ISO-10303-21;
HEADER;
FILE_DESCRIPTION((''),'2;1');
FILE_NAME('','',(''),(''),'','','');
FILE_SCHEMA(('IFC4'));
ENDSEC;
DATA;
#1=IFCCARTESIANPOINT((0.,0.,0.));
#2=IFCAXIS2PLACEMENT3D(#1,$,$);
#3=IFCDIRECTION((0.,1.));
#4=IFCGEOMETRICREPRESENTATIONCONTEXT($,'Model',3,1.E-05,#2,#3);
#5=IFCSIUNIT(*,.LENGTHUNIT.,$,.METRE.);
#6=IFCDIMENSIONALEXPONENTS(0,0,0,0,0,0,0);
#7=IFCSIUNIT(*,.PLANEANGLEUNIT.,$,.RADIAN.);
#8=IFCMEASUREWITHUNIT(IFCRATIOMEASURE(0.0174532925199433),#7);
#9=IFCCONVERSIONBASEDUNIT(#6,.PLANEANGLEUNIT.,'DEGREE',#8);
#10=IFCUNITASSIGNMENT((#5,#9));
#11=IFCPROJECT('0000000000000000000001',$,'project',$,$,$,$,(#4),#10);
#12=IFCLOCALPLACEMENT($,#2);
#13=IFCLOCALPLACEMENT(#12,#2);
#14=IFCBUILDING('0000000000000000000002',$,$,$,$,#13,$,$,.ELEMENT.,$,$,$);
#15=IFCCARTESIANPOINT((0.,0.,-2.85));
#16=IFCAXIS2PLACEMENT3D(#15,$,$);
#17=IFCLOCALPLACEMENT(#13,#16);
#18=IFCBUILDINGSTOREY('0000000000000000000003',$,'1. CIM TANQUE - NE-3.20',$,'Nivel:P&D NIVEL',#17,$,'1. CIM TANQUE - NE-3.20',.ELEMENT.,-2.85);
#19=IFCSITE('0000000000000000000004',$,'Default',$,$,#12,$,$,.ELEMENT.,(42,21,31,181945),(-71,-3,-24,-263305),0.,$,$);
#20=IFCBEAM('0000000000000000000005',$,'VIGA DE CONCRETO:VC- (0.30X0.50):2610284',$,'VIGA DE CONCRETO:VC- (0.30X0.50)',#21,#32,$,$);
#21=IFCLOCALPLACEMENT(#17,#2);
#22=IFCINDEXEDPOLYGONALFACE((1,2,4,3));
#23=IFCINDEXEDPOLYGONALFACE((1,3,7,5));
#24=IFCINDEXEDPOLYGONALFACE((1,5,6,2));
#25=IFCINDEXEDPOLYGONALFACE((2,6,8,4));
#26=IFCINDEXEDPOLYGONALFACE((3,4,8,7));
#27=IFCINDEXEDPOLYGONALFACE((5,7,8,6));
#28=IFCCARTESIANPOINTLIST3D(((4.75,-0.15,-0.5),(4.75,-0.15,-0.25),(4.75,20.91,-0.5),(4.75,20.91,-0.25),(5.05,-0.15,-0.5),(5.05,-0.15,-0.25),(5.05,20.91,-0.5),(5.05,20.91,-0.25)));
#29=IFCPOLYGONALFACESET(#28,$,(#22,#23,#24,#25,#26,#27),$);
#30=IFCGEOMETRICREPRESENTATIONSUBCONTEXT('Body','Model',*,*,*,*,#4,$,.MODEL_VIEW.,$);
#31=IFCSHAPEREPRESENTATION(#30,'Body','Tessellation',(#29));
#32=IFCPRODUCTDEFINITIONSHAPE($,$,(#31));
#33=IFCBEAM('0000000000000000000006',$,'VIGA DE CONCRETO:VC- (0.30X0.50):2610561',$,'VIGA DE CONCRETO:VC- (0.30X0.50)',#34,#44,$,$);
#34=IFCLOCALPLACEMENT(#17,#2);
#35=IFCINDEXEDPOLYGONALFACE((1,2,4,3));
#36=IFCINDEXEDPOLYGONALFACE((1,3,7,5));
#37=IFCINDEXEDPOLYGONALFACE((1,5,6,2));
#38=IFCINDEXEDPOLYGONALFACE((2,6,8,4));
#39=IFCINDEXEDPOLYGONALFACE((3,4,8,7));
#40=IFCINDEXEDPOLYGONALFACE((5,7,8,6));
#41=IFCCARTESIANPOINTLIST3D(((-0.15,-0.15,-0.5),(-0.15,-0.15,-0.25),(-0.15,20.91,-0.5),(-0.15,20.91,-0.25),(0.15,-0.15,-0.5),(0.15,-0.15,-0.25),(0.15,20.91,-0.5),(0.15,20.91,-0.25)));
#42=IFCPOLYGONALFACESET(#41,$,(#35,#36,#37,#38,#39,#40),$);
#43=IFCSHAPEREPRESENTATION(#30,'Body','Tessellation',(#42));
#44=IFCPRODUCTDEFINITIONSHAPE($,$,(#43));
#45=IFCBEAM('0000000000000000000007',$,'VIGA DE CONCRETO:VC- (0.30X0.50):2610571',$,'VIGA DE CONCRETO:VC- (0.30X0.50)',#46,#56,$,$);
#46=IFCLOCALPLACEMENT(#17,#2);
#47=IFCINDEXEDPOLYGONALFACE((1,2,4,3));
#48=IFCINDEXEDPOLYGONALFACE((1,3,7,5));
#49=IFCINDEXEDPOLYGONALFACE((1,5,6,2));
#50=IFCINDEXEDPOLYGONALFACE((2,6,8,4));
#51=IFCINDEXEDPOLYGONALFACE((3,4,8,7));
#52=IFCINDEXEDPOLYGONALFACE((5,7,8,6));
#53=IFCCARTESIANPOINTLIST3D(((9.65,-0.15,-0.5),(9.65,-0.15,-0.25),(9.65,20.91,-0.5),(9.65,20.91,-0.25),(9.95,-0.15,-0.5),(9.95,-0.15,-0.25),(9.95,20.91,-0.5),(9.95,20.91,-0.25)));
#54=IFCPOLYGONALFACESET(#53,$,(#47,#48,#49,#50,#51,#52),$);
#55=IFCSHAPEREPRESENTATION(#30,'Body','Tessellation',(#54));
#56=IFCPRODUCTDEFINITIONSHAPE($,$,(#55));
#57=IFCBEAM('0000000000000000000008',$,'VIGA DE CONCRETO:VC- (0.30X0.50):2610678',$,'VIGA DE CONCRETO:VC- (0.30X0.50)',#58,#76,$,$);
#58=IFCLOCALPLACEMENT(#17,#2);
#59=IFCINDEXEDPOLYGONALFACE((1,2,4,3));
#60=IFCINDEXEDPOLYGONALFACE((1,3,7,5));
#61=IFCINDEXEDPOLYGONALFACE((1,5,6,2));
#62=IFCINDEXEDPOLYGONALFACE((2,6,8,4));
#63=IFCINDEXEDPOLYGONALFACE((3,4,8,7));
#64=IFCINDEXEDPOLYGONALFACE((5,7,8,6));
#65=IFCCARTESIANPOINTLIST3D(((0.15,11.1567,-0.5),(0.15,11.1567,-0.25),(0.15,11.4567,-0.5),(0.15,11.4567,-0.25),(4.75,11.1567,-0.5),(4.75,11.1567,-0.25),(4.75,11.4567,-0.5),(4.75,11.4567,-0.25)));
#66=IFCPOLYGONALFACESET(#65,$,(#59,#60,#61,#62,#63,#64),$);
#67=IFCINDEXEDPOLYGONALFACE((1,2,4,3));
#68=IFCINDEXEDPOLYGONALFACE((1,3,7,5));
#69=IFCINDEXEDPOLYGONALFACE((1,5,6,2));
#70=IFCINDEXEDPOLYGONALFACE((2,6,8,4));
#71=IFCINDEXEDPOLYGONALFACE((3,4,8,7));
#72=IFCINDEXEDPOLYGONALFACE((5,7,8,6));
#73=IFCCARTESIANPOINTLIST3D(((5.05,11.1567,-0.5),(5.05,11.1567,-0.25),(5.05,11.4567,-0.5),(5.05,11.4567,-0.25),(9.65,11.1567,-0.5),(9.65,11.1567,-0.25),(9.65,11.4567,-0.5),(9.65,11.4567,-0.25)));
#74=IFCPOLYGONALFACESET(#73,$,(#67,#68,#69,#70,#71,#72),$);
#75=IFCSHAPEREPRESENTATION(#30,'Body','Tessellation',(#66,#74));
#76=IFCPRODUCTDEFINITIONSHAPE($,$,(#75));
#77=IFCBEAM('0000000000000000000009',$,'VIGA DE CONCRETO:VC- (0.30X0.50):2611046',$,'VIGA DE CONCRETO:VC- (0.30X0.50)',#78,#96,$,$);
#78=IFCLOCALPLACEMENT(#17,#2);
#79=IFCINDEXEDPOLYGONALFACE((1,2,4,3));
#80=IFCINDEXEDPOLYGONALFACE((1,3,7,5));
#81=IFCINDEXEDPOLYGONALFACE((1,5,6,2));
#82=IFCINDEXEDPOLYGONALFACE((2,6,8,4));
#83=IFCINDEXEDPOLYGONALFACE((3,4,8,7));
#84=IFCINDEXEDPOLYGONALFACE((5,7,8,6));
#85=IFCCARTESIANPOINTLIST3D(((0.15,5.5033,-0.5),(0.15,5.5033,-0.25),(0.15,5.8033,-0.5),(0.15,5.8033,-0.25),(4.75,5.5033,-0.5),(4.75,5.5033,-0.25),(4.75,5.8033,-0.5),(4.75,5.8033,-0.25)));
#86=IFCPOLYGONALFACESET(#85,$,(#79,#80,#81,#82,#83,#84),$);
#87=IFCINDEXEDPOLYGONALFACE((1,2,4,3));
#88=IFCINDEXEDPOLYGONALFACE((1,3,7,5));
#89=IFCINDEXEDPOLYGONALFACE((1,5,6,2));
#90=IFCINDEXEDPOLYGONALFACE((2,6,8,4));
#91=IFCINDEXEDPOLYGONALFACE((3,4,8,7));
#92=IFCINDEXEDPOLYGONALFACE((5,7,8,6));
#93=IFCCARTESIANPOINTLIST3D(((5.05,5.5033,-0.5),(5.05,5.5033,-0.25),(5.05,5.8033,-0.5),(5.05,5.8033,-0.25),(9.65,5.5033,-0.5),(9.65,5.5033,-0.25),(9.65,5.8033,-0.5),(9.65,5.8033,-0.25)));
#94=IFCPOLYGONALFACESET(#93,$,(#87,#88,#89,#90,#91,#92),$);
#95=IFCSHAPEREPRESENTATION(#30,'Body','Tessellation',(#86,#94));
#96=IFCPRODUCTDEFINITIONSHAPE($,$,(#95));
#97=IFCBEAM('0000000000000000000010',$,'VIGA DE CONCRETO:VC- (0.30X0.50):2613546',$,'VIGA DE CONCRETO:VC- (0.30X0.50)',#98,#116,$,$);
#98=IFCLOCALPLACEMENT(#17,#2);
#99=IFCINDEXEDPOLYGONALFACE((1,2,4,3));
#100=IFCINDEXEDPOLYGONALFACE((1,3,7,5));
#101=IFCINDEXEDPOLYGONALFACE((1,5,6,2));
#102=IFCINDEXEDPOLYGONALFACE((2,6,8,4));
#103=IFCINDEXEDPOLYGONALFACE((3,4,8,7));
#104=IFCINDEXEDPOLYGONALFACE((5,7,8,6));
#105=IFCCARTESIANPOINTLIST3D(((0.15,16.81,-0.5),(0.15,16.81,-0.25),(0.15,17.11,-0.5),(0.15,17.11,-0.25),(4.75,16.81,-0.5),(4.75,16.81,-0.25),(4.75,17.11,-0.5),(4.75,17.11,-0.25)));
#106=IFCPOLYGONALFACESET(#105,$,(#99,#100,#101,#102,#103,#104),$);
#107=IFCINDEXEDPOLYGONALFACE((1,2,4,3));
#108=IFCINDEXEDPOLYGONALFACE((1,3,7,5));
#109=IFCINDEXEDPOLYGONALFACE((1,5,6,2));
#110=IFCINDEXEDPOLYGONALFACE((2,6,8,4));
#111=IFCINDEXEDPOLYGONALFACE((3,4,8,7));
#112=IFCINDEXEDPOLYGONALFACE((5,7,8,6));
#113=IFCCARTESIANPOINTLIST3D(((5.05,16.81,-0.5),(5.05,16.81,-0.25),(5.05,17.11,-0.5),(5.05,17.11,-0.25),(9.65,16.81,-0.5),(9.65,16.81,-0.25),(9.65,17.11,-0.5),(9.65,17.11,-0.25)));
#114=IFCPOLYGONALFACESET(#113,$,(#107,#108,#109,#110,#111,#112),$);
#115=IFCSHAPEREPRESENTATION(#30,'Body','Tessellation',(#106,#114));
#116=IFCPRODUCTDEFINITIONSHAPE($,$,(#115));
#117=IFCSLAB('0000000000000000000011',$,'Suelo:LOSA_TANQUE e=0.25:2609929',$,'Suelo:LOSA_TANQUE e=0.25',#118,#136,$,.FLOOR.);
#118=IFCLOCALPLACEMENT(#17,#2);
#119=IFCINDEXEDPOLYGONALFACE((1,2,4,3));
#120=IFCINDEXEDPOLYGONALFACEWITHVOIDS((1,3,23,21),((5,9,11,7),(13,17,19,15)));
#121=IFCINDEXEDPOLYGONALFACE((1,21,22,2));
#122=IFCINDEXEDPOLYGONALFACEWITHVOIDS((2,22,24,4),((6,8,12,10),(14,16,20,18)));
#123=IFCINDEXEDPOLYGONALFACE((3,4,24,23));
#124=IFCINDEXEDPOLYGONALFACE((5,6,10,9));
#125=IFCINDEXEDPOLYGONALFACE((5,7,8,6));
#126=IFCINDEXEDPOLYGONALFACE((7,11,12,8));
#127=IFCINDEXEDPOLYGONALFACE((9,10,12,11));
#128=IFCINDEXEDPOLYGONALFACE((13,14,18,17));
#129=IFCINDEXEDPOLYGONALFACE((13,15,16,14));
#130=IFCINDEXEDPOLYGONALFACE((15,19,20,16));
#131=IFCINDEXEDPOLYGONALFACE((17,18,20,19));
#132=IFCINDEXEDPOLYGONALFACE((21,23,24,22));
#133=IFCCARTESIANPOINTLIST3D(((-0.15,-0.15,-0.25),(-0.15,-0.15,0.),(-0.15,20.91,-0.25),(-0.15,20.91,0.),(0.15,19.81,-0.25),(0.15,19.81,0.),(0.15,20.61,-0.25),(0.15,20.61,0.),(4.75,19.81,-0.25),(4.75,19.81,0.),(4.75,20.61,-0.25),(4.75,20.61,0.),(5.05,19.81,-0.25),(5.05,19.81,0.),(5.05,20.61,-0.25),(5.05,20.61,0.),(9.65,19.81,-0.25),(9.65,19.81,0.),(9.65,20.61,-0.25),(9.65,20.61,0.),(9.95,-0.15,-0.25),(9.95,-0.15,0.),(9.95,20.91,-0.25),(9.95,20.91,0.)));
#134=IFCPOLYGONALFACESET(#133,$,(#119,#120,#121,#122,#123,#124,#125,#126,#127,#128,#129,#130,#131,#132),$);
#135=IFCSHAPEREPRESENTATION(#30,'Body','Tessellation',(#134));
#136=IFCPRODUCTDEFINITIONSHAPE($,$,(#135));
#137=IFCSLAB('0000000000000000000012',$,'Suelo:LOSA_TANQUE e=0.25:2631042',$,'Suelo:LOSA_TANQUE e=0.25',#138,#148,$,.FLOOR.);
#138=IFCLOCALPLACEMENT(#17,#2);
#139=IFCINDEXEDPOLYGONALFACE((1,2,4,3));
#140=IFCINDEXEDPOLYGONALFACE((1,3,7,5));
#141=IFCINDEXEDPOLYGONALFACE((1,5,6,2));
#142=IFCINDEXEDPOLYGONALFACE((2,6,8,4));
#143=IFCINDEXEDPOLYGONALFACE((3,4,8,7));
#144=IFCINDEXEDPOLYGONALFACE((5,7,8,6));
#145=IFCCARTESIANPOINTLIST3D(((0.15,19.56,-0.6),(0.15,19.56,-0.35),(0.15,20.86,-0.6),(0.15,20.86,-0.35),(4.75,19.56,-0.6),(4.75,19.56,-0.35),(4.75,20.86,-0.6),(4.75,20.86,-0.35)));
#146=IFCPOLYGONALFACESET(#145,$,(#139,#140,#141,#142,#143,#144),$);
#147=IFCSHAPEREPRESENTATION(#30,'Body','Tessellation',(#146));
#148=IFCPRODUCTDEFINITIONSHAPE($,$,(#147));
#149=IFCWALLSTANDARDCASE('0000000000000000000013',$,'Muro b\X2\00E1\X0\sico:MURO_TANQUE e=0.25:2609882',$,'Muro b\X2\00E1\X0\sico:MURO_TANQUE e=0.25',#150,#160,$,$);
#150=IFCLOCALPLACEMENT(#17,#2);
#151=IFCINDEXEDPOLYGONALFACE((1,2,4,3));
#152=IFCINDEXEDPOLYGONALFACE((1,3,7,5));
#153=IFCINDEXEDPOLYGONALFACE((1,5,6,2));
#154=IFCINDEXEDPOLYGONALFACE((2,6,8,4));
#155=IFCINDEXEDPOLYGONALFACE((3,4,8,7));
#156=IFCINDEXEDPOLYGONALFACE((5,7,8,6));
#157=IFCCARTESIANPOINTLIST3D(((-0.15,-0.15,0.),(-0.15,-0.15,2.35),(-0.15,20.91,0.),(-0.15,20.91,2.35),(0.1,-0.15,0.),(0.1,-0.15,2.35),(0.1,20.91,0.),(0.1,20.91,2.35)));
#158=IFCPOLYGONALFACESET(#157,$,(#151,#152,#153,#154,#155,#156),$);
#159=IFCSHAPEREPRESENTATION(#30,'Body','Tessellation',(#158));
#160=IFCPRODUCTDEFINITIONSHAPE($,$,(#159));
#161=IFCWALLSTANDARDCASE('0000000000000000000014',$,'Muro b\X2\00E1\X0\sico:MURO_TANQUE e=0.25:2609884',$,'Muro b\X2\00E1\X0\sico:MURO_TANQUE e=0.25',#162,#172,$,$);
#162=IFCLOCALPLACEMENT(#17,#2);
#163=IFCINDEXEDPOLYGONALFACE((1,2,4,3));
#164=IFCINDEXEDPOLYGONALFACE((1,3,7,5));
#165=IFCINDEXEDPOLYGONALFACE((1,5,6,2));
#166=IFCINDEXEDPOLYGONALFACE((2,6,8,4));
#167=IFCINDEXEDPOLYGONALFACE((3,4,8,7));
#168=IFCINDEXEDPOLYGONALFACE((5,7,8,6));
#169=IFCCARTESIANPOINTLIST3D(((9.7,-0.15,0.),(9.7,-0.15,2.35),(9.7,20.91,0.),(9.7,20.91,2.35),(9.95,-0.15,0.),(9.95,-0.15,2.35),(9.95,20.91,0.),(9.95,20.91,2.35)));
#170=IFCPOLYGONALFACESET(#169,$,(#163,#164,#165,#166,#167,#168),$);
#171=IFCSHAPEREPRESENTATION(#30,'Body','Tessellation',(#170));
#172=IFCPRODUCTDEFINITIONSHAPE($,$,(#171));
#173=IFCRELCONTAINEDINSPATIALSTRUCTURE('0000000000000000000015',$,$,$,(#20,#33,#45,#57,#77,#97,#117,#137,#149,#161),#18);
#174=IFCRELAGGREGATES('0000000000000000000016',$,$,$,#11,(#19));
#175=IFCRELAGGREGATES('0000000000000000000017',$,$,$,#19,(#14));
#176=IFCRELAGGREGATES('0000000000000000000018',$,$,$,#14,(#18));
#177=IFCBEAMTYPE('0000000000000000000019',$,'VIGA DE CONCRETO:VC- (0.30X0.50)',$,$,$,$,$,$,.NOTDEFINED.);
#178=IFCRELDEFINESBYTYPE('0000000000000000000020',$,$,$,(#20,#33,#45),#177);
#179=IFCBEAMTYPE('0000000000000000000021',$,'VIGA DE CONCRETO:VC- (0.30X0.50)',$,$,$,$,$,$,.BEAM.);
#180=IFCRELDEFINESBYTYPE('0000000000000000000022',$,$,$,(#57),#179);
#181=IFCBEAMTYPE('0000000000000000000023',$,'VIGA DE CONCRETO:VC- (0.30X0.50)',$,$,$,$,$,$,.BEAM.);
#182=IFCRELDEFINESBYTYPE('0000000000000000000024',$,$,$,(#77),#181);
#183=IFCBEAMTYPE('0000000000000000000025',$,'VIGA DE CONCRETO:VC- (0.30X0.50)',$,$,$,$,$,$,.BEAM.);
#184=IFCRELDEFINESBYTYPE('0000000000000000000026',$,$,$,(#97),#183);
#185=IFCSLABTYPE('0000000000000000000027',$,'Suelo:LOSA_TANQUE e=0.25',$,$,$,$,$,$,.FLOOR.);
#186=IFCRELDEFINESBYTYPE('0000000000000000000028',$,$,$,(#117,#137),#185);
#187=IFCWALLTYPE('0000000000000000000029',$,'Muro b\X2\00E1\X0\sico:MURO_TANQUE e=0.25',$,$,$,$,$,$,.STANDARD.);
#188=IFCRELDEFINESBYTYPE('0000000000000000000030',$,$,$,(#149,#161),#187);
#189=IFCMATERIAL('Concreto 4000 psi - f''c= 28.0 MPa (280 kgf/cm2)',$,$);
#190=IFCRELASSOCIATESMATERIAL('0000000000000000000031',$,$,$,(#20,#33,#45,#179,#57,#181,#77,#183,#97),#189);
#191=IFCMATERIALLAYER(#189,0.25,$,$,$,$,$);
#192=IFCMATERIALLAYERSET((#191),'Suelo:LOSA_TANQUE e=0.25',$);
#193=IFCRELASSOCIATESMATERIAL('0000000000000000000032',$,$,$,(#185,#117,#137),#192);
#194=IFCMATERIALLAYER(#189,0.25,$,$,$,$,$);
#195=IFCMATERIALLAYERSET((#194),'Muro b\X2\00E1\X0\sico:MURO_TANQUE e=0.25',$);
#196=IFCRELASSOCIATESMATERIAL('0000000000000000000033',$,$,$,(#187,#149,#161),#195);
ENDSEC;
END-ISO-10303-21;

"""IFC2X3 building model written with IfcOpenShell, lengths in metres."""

from ifc_helpers import new_model, entity, si_unit, converted_unit, direction, frame, frame_2d, origin, origin_2d_with_axis, place, context, subcontext, project, spatial, rectangle, extrude, source, transform, mapped, material, layer, layer_set, layer_usage, type_object, type_shapes, element, save


model = new_model("IFC2X3")

# Units and contexts
model_context = context("Model", 3, precision=1e-05, world=origin(), true_north=direction((0.0, 1.0)))
body_context = subcontext(model_context, "Body", "Model", "MODEL_VIEW")
ifc_project = project(units=[si_unit("LENGTHUNIT", "METRE"), converted_unit("PLANEANGLEUNIT", "DEGREE", entity("IfcRatioMeasure", 0.0174532925199433), si_unit("PLANEANGLEUNIT", "RADIAN"), dimensions=[0, 0, 0, 0, 0, 0, 0])], contexts=[model_context])

# Site, building, storey
site_placement = place(None, origin())
site = spatial("IfcSite", under=ifc_project, at=site_placement, Name="Default", CompositionType="ELEMENT", RefLatitude=(42, 21, 31, 181945), RefLongitude=(-71, -3, -24, -263305), RefElevation=0.0)
building_placement = place(site_placement, origin())
building = spatial("IfcBuilding", under=site, at=building_placement, CompositionType="ELEMENT")
storey_placement = place(building_placement, frame((0.0, 0.0, -2.85)))
storey = spatial("IfcBuildingStorey", under=building, at=storey_placement, Name="1. CIM TANQUE - NE-3.20", ObjectType="Nivel:P&D NIVEL", LongName="1. CIM TANQUE - NE-3.20", CompositionType="ELEMENT", Elevation=-2.85)

# Beams
ifc_material = material(Name="Concreto 4000 psi - f'c= 28.0 MPa (280 kgf/cm2)")
beam_type_1 = type_object("IfcBeamType", Name="VIGA DE CONCRETO:VC- (0.30X0.50)", PredefinedType="NOTDEFINED")
beam_1_placement = place(storey_placement, frame((4.9, 20.785, 0.0), z_axis=(0.0, 0.0, 1.0), x_axis=(0.0, -1.0, 0.0)))
element("IfcBeam", 1, at=beam_1_placement, inside=storey, type_object=beam_type_1, material=ifc_material, Name="VIGA DE CONCRETO:VC- (0.30X0.50):2610284", ObjectType="VIGA DE CONCRETO:VC- (0.30X0.50)", context=body_context, shape_type="SweptSolid", body=[
    extrude(rectangle(XDim=0.25, YDim=0.3, at=origin_2d_with_axis()), frame((-0.125, 0.0, -0.375), z_axis=(1.0, 0.0, 0.0), x_axis=(0.0, 0.0, -1.0)), (0.0, 0.0, 1.0), 21.06),
])
beam_2_placement = place(storey_placement, frame((0.0, 20.785, 0.0), z_axis=(0.0, 0.0, 1.0), x_axis=(0.0, -1.0, 0.0)))
element("IfcBeam", 2, at=beam_2_placement, inside=storey, type_object=beam_type_1, material=ifc_material, Name="VIGA DE CONCRETO:VC- (0.30X0.50):2610561", ObjectType="VIGA DE CONCRETO:VC- (0.30X0.50)", context=body_context, shape_type="SweptSolid", body=[
    extrude(rectangle(XDim=0.25, YDim=0.3, at=frame_2d((0.0, 0.0), x_axis=(1.0, 0.0))), frame((-0.125, 0.0, -0.375), z_axis=(1.0, 0.0, 0.0), x_axis=(0.0, 0.0, -1.0)), (0.0, 0.0, 1.0), 21.06),
])
beam_3_placement = place(storey_placement, frame((9.8, 20.785, 0.0), z_axis=(0.0, 0.0, 1.0), x_axis=(0.0, -1.0, 0.0)))
element("IfcBeam", 3, at=beam_3_placement, inside=storey, type_object=beam_type_1, material=ifc_material, Name="VIGA DE CONCRETO:VC- (0.30X0.50):2610571", ObjectType="VIGA DE CONCRETO:VC- (0.30X0.50)", context=body_context, shape_type="SweptSolid", body=[
    extrude(rectangle(XDim=0.25, YDim=0.3, at=frame_2d((0.0, 0.0), x_axis=(1.0, 0.0))), frame((-0.125, 0.0, -0.375), z_axis=(1.0, 0.0, 0.0), x_axis=(0.0, 0.0, -1.0)), (0.0, 0.0, 1.0), 21.06),
])
beam_type_2 = type_object("IfcBeamType", Name="VIGA DE CONCRETO:VC- (0.30X0.50)", PredefinedType="BEAM", material=ifc_material)
shared_shape_1 = source(origin(), body_context, "Body", "SweptSolid", [
    extrude(rectangle(XDim=0.25, YDim=0.3, at=frame_2d((0.0, 0.0), x_axis=(1.0, 0.0))), frame((0.15, 11.3067, -3.225), z_axis=(1.0, 0.0, 0.0), x_axis=(0.0, 0.0, -1.0)), (0.0, 0.0, 1.0), 4.6),
    extrude(rectangle(XDim=0.25, YDim=0.3, at=frame_2d((0.0, 0.0), x_axis=(1.0, 0.0))), frame((5.05, 11.3067, -3.225), z_axis=(1.0, 0.0, 0.0), x_axis=(0.0, 0.0, -1.0)), (0.0, 0.0, 1.0), 4.6),
])
type_shapes(beam_type_2, [shared_shape_1])
beam_4_placement = place(storey_placement, frame((0.0, 0.0, 2.85)))
element("IfcBeam", 4, at=beam_4_placement, inside=storey, type_object=beam_type_2, material=ifc_material, Name="VIGA DE CONCRETO:VC- (0.30X0.50):2610678", ObjectType="VIGA DE CONCRETO:VC- (0.30X0.50)", context=body_context, shape_type="MappedRepresentation", body=[
    mapped(shared_shape_1, transform((0.0, 0.0, 0.0), scale=1.0)),
])
beam_type_3 = type_object("IfcBeamType", Name="VIGA DE CONCRETO:VC- (0.30X0.50)", PredefinedType="BEAM", material=ifc_material)
shared_shape_2 = source(origin(), body_context, "Body", "SweptSolid", [
    extrude(rectangle(XDim=0.25, YDim=0.3, at=frame_2d((0.0, 0.0), x_axis=(1.0, 0.0))), frame((0.15, 5.6533, -3.225), z_axis=(1.0, 0.0, 0.0), x_axis=(0.0, 0.0, -1.0)), (0.0, 0.0, 1.0), 4.6),
    extrude(rectangle(XDim=0.25, YDim=0.3, at=frame_2d((0.0, 0.0), x_axis=(1.0, 0.0))), frame((5.05, 5.6533, -3.225), z_axis=(1.0, 0.0, 0.0), x_axis=(0.0, 0.0, -1.0)), (0.0, 0.0, 1.0), 4.6),
])
type_shapes(beam_type_3, [shared_shape_2])
beam_5_placement = place(storey_placement, frame((0.0, 0.0, 2.85)))
element("IfcBeam", 5, at=beam_5_placement, inside=storey, type_object=beam_type_3, material=ifc_material, Name="VIGA DE CONCRETO:VC- (0.30X0.50):2611046", ObjectType="VIGA DE CONCRETO:VC- (0.30X0.50)", context=body_context, shape_type="MappedRepresentation", body=[
    mapped(shared_shape_2, transform((0.0, 0.0, 0.0), scale=1.0)),
])
beam_type_4 = type_object("IfcBeamType", Name="VIGA DE CONCRETO:VC- (0.30X0.50)", PredefinedType="BEAM", material=ifc_material)
shared_shape_3 = source(origin(), body_context, "Body", "SweptSolid", [
    extrude(rectangle(XDim=0.25, YDim=0.3, at=frame_2d((0.0, 0.0), x_axis=(1.0, 0.0))), frame((0.15, 16.96, -3.225), z_axis=(1.0, 0.0, 0.0), x_axis=(0.0, 0.0, -1.0)), (0.0, 0.0, 1.0), 4.6),
    extrude(rectangle(XDim=0.25, YDim=0.3, at=frame_2d((0.0, 0.0), x_axis=(1.0, 0.0))), frame((5.05, 16.96, -3.225), z_axis=(1.0, 0.0, 0.0), x_axis=(0.0, 0.0, -1.0)), (0.0, 0.0, 1.0), 4.6),
])
type_shapes(beam_type_4, [shared_shape_3])
beam_6_placement = place(storey_placement, frame((0.0, 0.0, 2.85)))
element("IfcBeam", 6, at=beam_6_placement, inside=storey, type_object=beam_type_4, material=ifc_material, Name="VIGA DE CONCRETO:VC- (0.30X0.50):2613546", ObjectType="VIGA DE CONCRETO:VC- (0.30X0.50)", context=body_context, shape_type="MappedRepresentation", body=[
    mapped(shared_shape_3, transform((0.0, 0.0, 0.0), scale=1.0)),
])

# Slab, openings
ifc_layer_1 = layer(ifc_material, 0.25)
ifc_layer_set_1 = layer_set([ifc_layer_1], Name="Suelo:LOSA_TANQUE e=0.25")
ifc_layer_usage_1 = layer_usage(ifc_layer_set_1, "AXIS3", "POSITIVE", 0.0)
slab_type = type_object("IfcSlabType", Name="Suelo:LOSA_TANQUE e=0.25", PredefinedType="FLOOR", material=ifc_layer_set_1)
slab_1_placement = place(storey_placement, frame((-0.15, -0.15, -0.25)))
slab_1 = element("IfcSlab", 7, at=slab_1_placement, inside=storey, type_object=slab_type, material=ifc_layer_usage_1, Name="Suelo:LOSA_TANQUE e=0.25:2609929", ObjectType="Suelo:LOSA_TANQUE e=0.25", PredefinedType="FLOOR", context=body_context, shape_type="SweptSolid", body=[
    extrude(rectangle(XDim=21.06, YDim=10.1, at=frame_2d((0.0, 0.0), x_axis=(0.0, -1.0))), frame((5.05, 10.53, 0.25), z_axis=(0.0, 0.0, -1.0), x_axis=(-1.0, 0.0, 0.0)), (0.0, 0.0, 1.0), 0.25),
])
opening_1_placement = place(slab_1_placement, origin())
element("IfcOpeningElement", 8, at=opening_1_placement, cuts=slab_1, ObjectType="Opening", context=body_context, shape_type="SweptSolid", body=[
    extrude(rectangle(XDim=0.8, YDim=4.6, at=frame_2d((0.0, 0.0), x_axis=(1.0, 0.0))), frame((2.6, 20.36, 0.25), z_axis=(0.0, 0.0, -1.0), x_axis=(0.0, -1.0, 0.0)), (0.0, 0.0, 1.0), 0.25),
])
opening_2_placement = place(slab_1_placement, origin())
element("IfcOpeningElement", 9, at=opening_2_placement, cuts=slab_1, ObjectType="Opening", context=body_context, shape_type="SweptSolid", body=[
    extrude(rectangle(XDim=0.8, YDim=4.6, at=origin_2d_with_axis()), frame((7.5, 20.36, 0.25), z_axis=(0.0, 0.0, -1.0), x_axis=(0.0, -1.0, 0.0)), (0.0, 0.0, 1.0), 0.25),
])

# Slab
slab_2_placement = place(storey_placement, frame((0.15, 19.56, -0.6)))
element("IfcSlab", 10, at=slab_2_placement, inside=storey, type_object=slab_type, material=ifc_layer_usage_1, Name="Suelo:LOSA_TANQUE e=0.25:2631042", ObjectType="Suelo:LOSA_TANQUE e=0.25", PredefinedType="FLOOR", context=body_context, shape_type="SweptSolid", body=[
    extrude(rectangle(XDim=4.6, YDim=1.3, at=frame_2d((2.45, 0.0), x_axis=(-1.0, 0.0))), frame((4.75, 0.65, 0.25), z_axis=(0.0, 0.0, -1.0), x_axis=(-1.0, 0.0, 0.0)), (0.0, 0.0, 1.0), 0.25),
])

# Walls
ifc_layer_2 = layer(ifc_material, 0.25)
ifc_layer_set_2 = layer_set([ifc_layer_2], Name="Muro básico:MURO_TANQUE e=0.25")
ifc_layer_usage_2 = layer_usage(ifc_layer_set_2, "AXIS2", "NEGATIVE", 0.125)
wall_type = type_object("IfcWallType", Name="Muro básico:MURO_TANQUE e=0.25", PredefinedType="STANDARD", material=ifc_layer_set_2)
wall_1_placement = place(storey_placement, frame((-0.025, 20.91, 0.0), z_axis=(0.0, 0.0, 1.0), x_axis=(0.0, -1.0, 0.0)))
element("IfcWallStandardCase", 11, at=wall_1_placement, inside=storey, type_object=wall_type, material=ifc_layer_usage_2, Name="Muro básico:MURO_TANQUE e=0.25:2609882", ObjectType="Muro básico:MURO_TANQUE e=0.25", context=body_context, shape_type="SweptSolid", body=[
    extrude(rectangle(XDim=21.06, YDim=0.25, at=frame_2d((10.53, 0.0), x_axis=(-1.0, 0.0))), origin(), (0.0, 0.0, 1.0), 2.35),
])
wall_2_placement = place(storey_placement, frame((9.825, 20.91, 0.0), z_axis=(0.0, 0.0, 1.0), x_axis=(0.0, -1.0, 0.0)))
element("IfcWallStandardCase", 12, at=wall_2_placement, inside=storey, type_object=wall_type, material=ifc_layer_usage_2, Name="Muro básico:MURO_TANQUE e=0.25:2609884", ObjectType="Muro básico:MURO_TANQUE e=0.25", context=body_context, shape_type="SweptSolid", body=[
    extrude(rectangle(XDim=21.06, YDim=0.25, at=frame_2d((10.53, 0.0), x_axis=(-1.0, 0.0))), origin(), (0.0, 0.0, 1.0), 2.35),
])

save(model, "model.ifc")
